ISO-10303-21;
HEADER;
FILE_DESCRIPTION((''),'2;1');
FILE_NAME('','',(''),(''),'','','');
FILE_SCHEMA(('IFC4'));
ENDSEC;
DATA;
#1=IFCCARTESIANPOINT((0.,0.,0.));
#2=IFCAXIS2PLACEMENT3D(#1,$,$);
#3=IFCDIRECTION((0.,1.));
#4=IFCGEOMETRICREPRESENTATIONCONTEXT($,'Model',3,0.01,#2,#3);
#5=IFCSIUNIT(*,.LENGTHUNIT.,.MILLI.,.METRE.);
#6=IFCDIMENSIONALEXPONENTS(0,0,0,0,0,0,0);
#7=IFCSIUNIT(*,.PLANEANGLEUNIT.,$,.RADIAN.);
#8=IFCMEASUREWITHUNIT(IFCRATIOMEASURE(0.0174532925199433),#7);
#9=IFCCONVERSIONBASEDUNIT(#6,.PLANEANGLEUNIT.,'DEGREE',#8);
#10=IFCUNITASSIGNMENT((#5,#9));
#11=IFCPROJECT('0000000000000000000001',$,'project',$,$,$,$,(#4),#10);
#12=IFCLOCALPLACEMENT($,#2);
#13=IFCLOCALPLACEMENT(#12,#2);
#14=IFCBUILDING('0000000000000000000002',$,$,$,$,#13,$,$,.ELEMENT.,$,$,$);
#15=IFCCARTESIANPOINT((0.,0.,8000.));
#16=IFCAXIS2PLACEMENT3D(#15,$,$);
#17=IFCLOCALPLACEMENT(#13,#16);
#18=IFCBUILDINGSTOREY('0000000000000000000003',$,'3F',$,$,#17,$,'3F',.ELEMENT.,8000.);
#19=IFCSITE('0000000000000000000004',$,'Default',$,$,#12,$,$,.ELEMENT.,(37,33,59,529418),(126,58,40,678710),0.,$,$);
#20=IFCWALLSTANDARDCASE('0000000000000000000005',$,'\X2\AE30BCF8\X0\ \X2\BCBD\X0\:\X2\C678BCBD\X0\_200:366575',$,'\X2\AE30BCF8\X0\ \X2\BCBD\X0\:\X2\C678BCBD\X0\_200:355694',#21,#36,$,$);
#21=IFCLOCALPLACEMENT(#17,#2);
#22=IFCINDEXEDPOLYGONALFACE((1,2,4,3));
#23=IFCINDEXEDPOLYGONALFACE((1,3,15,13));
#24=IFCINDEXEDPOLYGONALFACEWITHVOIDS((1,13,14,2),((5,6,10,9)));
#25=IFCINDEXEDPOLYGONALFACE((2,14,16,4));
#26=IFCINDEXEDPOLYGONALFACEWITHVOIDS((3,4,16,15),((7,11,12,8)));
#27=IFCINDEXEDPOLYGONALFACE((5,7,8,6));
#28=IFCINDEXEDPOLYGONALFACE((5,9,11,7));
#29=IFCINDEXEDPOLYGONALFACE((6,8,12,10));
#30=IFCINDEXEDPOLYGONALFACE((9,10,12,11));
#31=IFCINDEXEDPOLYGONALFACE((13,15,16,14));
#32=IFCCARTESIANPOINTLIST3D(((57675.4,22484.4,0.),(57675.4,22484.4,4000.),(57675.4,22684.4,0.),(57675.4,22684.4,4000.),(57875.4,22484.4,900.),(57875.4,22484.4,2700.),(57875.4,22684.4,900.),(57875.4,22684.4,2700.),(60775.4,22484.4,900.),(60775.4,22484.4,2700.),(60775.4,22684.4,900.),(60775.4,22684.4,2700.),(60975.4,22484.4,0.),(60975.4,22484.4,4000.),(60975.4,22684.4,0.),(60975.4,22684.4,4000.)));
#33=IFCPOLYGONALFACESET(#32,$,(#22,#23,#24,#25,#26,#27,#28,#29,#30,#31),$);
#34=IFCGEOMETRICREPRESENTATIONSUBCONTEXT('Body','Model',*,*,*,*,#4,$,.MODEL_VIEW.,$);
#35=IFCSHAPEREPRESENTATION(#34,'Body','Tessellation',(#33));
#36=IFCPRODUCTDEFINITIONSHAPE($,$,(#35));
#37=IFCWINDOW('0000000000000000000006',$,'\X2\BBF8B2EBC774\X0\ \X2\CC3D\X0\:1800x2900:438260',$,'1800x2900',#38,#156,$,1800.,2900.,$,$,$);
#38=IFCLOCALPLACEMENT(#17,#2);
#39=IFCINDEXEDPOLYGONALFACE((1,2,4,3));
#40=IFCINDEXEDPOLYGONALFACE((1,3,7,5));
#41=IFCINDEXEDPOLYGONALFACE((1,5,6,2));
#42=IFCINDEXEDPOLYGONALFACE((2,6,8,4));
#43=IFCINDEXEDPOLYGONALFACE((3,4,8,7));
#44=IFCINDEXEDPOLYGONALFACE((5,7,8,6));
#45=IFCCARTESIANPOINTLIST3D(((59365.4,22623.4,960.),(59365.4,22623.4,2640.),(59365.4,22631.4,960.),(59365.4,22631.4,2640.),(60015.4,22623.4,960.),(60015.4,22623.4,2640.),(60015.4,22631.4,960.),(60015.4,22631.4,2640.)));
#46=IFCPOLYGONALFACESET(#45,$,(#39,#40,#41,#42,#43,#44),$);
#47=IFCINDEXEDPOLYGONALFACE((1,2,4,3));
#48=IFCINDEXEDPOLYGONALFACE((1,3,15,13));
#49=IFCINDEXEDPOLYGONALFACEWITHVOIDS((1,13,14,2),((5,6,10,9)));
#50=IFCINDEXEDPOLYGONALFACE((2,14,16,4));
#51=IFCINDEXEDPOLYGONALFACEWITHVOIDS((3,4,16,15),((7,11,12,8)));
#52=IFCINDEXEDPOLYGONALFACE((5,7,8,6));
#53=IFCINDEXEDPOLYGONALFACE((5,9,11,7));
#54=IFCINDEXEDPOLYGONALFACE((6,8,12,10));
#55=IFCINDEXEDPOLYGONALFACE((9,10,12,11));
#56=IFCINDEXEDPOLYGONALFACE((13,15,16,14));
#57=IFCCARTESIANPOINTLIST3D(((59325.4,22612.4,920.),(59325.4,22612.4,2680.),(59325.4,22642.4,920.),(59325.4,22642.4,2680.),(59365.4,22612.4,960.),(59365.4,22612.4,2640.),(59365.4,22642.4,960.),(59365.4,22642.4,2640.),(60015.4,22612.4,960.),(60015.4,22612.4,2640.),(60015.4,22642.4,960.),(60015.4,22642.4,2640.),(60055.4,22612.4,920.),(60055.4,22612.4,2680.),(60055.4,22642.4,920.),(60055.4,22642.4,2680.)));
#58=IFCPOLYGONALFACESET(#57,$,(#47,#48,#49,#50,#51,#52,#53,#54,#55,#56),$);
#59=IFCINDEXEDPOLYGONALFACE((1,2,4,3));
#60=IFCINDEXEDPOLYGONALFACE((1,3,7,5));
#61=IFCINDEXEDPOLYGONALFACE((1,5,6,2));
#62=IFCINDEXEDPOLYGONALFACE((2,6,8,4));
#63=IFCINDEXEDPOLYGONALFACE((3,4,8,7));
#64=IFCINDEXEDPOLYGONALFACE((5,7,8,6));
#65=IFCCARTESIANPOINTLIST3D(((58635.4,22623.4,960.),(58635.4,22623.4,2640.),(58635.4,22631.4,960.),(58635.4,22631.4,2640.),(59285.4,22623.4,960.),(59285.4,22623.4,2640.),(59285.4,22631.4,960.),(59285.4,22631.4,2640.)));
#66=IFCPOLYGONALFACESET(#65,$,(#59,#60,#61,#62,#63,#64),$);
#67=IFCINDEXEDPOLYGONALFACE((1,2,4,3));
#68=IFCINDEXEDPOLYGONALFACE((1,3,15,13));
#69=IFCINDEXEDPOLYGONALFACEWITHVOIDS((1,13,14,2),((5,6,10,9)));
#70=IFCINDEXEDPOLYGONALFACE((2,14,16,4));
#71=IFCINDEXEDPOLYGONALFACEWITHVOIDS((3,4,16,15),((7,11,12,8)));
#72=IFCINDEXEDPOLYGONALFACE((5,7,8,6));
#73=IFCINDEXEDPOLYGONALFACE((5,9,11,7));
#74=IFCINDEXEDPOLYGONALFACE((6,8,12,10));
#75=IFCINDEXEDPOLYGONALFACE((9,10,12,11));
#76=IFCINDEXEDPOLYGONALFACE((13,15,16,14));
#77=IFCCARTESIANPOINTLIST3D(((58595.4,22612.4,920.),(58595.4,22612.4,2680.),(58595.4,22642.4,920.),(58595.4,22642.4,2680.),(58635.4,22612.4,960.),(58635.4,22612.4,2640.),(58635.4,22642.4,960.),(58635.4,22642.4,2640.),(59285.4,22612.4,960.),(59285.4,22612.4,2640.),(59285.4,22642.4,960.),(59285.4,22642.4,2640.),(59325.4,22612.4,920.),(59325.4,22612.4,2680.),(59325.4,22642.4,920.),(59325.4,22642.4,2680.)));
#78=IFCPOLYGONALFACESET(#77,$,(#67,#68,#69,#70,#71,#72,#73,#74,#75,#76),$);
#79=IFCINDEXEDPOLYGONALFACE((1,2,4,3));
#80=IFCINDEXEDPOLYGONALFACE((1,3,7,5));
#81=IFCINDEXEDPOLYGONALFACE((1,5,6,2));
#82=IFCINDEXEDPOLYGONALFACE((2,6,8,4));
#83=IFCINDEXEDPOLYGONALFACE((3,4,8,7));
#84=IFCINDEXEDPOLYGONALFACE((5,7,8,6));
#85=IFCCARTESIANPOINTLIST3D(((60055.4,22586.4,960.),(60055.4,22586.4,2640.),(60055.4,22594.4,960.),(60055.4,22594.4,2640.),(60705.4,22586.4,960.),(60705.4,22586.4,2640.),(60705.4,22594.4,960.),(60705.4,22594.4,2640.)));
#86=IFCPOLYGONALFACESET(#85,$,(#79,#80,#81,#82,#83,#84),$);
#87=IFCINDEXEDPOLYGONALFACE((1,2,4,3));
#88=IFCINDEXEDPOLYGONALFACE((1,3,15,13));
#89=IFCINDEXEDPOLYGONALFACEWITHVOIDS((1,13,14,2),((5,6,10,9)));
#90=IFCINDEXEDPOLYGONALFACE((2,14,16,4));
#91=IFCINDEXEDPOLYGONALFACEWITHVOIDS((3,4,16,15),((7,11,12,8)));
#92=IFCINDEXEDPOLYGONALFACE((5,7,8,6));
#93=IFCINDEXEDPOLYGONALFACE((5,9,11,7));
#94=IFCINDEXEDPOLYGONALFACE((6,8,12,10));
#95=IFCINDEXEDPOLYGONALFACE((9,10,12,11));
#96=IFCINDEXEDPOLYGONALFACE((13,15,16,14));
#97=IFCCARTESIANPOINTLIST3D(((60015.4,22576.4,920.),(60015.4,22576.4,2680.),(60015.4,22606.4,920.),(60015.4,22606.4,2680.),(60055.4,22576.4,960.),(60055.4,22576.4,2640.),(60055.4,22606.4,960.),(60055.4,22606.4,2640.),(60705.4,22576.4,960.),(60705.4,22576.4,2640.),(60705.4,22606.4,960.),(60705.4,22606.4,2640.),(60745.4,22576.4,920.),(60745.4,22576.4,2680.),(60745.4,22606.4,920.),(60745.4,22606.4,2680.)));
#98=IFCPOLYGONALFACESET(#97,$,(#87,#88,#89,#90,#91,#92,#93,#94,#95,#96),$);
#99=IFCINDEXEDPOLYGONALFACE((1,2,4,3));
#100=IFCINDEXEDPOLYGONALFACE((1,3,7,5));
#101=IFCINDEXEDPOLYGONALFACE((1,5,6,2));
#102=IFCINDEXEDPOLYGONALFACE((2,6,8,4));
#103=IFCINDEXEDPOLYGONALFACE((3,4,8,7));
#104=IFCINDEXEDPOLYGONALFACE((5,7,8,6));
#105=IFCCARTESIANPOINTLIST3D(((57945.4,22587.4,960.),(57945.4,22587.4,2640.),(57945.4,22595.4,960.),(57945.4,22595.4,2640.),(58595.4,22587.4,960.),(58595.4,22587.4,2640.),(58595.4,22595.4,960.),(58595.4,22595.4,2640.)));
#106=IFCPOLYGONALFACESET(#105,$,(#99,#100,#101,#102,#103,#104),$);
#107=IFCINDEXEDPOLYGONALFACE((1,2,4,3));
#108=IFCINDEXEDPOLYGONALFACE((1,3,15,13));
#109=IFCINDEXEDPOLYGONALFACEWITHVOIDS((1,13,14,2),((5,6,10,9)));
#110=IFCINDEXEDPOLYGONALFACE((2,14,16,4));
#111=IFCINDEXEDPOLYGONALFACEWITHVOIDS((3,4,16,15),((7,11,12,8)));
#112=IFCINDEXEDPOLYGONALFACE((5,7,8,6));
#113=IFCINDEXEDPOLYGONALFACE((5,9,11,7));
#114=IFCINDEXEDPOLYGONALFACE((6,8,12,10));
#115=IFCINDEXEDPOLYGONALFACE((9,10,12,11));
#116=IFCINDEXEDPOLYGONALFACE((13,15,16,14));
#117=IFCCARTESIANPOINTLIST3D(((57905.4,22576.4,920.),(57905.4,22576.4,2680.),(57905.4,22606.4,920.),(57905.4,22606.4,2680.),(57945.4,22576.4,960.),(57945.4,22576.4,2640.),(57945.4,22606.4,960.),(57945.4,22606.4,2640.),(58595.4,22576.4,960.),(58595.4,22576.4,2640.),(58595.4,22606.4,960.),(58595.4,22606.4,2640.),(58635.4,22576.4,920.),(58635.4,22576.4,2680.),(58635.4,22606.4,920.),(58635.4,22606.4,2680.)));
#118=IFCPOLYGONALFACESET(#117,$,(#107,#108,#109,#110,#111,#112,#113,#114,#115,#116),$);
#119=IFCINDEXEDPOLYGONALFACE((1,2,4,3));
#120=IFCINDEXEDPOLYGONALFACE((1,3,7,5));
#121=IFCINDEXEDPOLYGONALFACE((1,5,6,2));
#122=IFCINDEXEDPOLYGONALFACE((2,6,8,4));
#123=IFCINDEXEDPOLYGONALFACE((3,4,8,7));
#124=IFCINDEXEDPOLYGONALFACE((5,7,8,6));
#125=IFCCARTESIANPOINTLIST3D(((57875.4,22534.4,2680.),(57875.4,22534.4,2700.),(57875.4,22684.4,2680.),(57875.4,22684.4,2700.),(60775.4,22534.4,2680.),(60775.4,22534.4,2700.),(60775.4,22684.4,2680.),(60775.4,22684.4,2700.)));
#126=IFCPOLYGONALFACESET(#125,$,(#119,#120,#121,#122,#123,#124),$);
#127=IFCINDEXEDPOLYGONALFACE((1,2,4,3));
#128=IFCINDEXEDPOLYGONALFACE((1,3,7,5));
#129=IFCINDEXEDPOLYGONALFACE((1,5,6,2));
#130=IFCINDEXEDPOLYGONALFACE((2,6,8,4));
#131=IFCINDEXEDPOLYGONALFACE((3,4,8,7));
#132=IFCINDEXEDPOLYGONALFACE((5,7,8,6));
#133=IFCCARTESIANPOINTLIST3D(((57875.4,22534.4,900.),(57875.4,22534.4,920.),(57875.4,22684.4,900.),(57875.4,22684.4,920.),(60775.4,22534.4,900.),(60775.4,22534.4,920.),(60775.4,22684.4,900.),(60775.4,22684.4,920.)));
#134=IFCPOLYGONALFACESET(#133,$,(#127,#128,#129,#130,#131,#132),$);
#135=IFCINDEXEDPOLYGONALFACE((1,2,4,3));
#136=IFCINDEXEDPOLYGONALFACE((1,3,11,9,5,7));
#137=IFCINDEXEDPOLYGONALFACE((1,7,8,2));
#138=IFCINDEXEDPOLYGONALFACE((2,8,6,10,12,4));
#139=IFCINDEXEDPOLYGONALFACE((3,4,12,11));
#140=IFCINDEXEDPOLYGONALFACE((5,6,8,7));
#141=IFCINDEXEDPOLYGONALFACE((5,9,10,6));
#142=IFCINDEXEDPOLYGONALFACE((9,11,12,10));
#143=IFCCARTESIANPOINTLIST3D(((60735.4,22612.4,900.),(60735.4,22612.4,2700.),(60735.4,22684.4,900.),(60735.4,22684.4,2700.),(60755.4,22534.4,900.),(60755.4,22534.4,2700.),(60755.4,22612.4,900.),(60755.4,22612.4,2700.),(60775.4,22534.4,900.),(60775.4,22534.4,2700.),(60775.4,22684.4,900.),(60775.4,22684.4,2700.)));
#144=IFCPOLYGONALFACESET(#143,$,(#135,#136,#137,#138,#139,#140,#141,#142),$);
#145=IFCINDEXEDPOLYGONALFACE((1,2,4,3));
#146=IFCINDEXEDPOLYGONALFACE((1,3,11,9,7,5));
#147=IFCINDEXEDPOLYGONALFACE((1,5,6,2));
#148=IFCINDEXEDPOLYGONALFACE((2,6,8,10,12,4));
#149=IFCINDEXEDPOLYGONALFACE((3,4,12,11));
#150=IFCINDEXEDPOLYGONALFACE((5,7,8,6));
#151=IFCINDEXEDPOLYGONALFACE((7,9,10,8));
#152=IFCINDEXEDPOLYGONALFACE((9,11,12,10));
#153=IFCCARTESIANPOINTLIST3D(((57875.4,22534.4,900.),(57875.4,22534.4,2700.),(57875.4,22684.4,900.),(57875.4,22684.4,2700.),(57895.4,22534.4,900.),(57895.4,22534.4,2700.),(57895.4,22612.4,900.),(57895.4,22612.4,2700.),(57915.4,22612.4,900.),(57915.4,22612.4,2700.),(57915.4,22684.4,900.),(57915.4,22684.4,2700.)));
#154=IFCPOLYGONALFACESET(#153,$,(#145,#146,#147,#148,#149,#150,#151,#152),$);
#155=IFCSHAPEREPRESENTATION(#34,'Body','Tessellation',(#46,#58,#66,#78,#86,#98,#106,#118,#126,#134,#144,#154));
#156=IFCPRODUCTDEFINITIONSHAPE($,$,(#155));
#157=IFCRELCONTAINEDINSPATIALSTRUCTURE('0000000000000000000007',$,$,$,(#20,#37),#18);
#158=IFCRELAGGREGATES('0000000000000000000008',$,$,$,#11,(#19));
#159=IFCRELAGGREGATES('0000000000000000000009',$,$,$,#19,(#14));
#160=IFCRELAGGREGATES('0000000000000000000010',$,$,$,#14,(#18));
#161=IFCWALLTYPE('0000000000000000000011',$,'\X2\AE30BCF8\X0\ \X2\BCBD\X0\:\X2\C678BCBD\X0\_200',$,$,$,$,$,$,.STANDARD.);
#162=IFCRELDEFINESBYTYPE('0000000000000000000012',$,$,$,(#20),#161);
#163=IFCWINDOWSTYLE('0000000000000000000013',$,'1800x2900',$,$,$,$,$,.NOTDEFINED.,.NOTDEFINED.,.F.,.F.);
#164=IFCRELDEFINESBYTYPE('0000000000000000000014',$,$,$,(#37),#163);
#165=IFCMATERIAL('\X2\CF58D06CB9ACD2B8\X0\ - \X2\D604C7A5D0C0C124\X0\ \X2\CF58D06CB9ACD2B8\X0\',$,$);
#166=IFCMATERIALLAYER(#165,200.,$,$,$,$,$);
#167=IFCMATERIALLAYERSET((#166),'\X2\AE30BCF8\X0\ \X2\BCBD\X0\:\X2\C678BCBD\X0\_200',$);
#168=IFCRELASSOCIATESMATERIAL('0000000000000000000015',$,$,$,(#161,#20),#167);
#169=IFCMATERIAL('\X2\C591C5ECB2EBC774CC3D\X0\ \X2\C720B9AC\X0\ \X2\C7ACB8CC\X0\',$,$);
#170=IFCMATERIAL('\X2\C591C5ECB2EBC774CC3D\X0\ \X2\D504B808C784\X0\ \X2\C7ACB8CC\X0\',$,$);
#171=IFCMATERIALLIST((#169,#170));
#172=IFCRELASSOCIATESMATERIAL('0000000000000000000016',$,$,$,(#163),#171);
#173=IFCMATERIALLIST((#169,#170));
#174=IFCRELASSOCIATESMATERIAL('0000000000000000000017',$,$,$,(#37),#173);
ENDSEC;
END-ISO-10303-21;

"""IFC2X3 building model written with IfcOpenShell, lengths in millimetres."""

from ifc_helpers import new_model, entity, si_unit, converted_unit, direction, frame, frame_2d, origin, origin_2d_with_axis, place, context, subcontext, project, spatial, polyline, rectangle, outline, extrude, source, transform, mapped, material, material_list, layer, layer_set, layer_usage, type_object, type_shapes, element, fill, save


model = new_model("IFC2X3")

# Units and contexts
model_context = context("Model", 3, precision=0.01, world=origin(), true_north=direction((0.0, 1.0)))
body_context = subcontext(model_context, "Body", "Model", "MODEL_VIEW")
ifc_project = project(units=[si_unit("LENGTHUNIT", "METRE", prefix="MILLI"), converted_unit("PLANEANGLEUNIT", "DEGREE", entity("IfcRatioMeasure", 0.0174532925199433), si_unit("PLANEANGLEUNIT", "RADIAN"), dimensions=[0, 0, 0, 0, 0, 0, 0])], contexts=[model_context])

# Site, building, storey
site_placement = place(None, origin())
site = spatial("IfcSite", under=ifc_project, at=site_placement, Name="Default", CompositionType="ELEMENT", RefLatitude=(37, 33, 59, 529418), RefLongitude=(126, 58, 40, 678710), RefElevation=0.0)
building_placement = place(site_placement, origin())
building = spatial("IfcBuilding", under=site, at=building_placement, CompositionType="ELEMENT")
storey_placement = place(building_placement, frame((0.0, 0.0, 8000.0)))
storey = spatial("IfcBuildingStorey", under=building, at=storey_placement, Name="3F", LongName="3F", CompositionType="ELEMENT", Elevation=8000.0)

# Wall, opening, window
ifc_material_1 = material(Name="콘크리트 - 현장타설 콘크리트")
ifc_layer_1 = layer(ifc_material_1, 200.0)
ifc_layer_set_1 = layer_set([ifc_layer_1], Name="기본 벽:외벽_200")
wall_type_1 = type_object("IfcWallType", Name="기본 벽:외벽_200", PredefinedType="STANDARD", material=ifc_layer_set_1)
ifc_material_2 = material(Name="양여닫이창 유리 재료")
ifc_material_3 = material(Name="양여닫이창 프레임 재료")
ifc_material_list_1 = material_list([ifc_material_2, ifc_material_3])
window_style = type_object("IfcWindowStyle", Name="1800x2900", ConstructionType="NOTDEFINED", OperationType="NOTDEFINED", ParameterTakesPrecedence=False, Sizeable=False, material=ifc_material_list_1)
shared_shape_1 = source(origin(), body_context, "Body", "SweptSolid", [
    extrude(rectangle(XDim=8.0, YDim=650.0, at=frame_2d((0.0, 0.0), x_axis=(1.0, 0.0))), frame((1815.0, 143.0, 60.0), z_axis=(0.0, 0.0, 1.0), x_axis=(0.0, 1.0, 0.0)), (0.0, 0.0, 1.0), 1680.0),
    extrude(outline(polyline([(-880.0, -365.0), (880.0, -365.0), (880.0, 365.0), (-880.0, 365.0), (-880.0, -365.0)]), holes=[polyline([(840.0, -325.0), (-840.0, -325.0), (-840.0, 325.0), (840.0, 325.0), (840.0, -325.0)])]), frame((1815.0, 128.0, 900.0), z_axis=(0.0, 1.0, 0.0), x_axis=(0.0, 0.0, -1.0)), (0.0, 0.0, 1.0), 30.0),
    extrude(rectangle(XDim=8.0, YDim=650.0, at=frame_2d((0.0, 0.0), x_axis=(1.0, 0.0))), frame((1085.0, 143.0, 60.0), z_axis=(0.0, 0.0, 1.0), x_axis=(0.0, 1.0, 0.0)), (0.0, 0.0, 1.0), 1680.0),
    extrude(outline(polyline([(-880.0, -365.0), (880.0, -365.0), (880.0, 365.0), (-880.0, 365.0), (-880.0, -365.0)]), holes=[polyline([(840.0, -325.0), (-840.0, -325.0), (-840.0, 325.0), (840.0, 325.0), (840.0, -325.0)])]), frame((1085.0, 128.0, 900.0), z_axis=(0.0, 1.0, 0.0), x_axis=(0.0, 0.0, -1.0)), (0.0, 0.0, 1.0), 30.0),
    extrude(rectangle(XDim=8.0, YDim=650.0, at=frame_2d((0.0, 0.0), x_axis=(1.0, 0.0))), frame((2505.0, 106.0, 60.0), z_axis=(0.0, 0.0, 1.0), x_axis=(0.0, 1.0, 0.0)), (0.0, 0.0, 1.0), 1680.0),
    extrude(outline(polyline([(-880.0, -365.0), (880.0, -365.0), (880.0, 365.0), (-880.0, 365.0), (-880.0, -365.0)]), holes=[polyline([(840.0, -325.0), (-840.0, -325.0), (-840.0, 325.0), (840.0, 325.0), (840.0, -325.0)])]), frame((2505.0, 92.0, 900.0), z_axis=(0.0, 1.0, 0.0), x_axis=(0.0, 0.0, -1.0)), (0.0, 0.0, 1.0), 30.0),
    extrude(rectangle(XDim=8.0, YDim=650.0, at=origin_2d_with_axis()), frame((395.0, 107.0, 60.0), z_axis=(0.0, 0.0, 1.0), x_axis=(0.0, 1.0, 0.0)), (0.0, 0.0, 1.0), 1680.0),
    extrude(outline(polyline([(-880.0, -365.0), (880.0, -365.0), (880.0, 365.0), (-880.0, 365.0), (-880.0, -365.0)]), holes=[polyline([(840.0, -325.0), (-840.0, -325.0), (-840.0, 325.0), (840.0, 325.0), (840.0, -325.0)])]), frame((395.0, 92.0, 900.0), z_axis=(0.0, 1.0, 0.0), x_axis=(0.0, 0.0, -1.0)), (0.0, 0.0, 1.0), 30.0),
    extrude(rectangle(XDim=2900.0, YDim=150.0, at=origin_2d_with_axis()), frame((1450.0, 125.0, 1780.0), z_axis=(0.0, 0.0, 1.0), x_axis=(-1.0, 0.0, 0.0)), (0.0, 0.0, 1.0), 20.0),
    extrude(rectangle(XDim=2900.0, YDim=150.0, at=origin_2d_with_axis()), frame((1450.0, 125.0, 0.0), z_axis=(0.0, 0.0, 1.0), x_axis=(-1.0, 0.0, 0.0)), (0.0, 0.0, 1.0), 20.0),
    extrude(outline(polyline([(-74.0, -20.0), (-2.0, -20.0), (-2.0, 0.0), (76.0, 0.0), (76.0, 20.0), (-74.0, 20.0), (-74.0, -20.0)])), frame((2880.0, 126.0, 0.0), z_axis=(0.0, 0.0, 1.0), x_axis=(0.0, -1.0, 0.0)), (0.0, 0.0, 1.0), 1800.0),
    extrude(outline(polyline([(-20.0, -74.0), (20.0, -74.0), (20.0, 76.0), (0.0, 76.0), (0.0, -2.0), (-20.0, -2.0), (-20.0, -74.0)])), frame((20.0, 126.0, 0.0), z_axis=(0.0, 0.0, 1.0), x_axis=(-1.0, 0.0, 0.0)), (0.0, 0.0, 1.0), 1800.0),
])
type_shapes(window_style, [shared_shape_1])
ifc_layer_usage_1 = layer_usage(ifc_layer_set_1, "AXIS2", "NEGATIVE", 100.0)
wall_1_placement = place(storey_placement, frame((60975.4, 22584.4, 0.0), z_axis=(0.0, 0.0, 1.0), x_axis=(-1.0, 0.0, 0.0)))
wall_1 = element("IfcWallStandardCase", 1, at=wall_1_placement, inside=storey, type_object=wall_type_1, material=ifc_layer_usage_1, Name="기본 벽:외벽_200:366575", ObjectType="기본 벽:외벽_200:355694", context=body_context, shape_type="SweptSolid", body=[
    extrude(rectangle(XDim=3300.0, YDim=200.0, at=frame_2d((1650.0, 0.0), x_axis=(-1.0, 0.0))), origin(), (0.0, 0.0, 1.0), 4000.0),
])
opening_1_placement = place(wall_1_placement, frame((3100.0, 100.0, 900.0)))
opening_1 = element("IfcOpeningElement", 2, at=opening_1_placement, cuts=wall_1, ObjectType="Opening", context=body_context, shape_type="SweptSolid", body=[
    extrude(rectangle(XDim=1800.0, YDim=2900.0, at=frame_2d((900.0, 1450.0), x_axis=(1.0, 0.0))), frame((0.0, 0.0, 0.0), z_axis=(0.0, -1.0, 0.0), x_axis=(0.0, 0.0, 1.0)), (0.0, 0.0, 1.0), 200.0),
])
ifc_material_list_2 = material_list([ifc_material_2, ifc_material_3])
window_1_placement = place(opening_1_placement, frame((0.0, 0.0, 0.0), z_axis=(0.0, 0.0, 1.0), x_axis=(-1.0, 0.0, 0.0)))
window_1 = element("IfcWindow", 3, at=window_1_placement, inside=storey, type_object=window_style, material=ifc_material_list_2, Name="미닫이 창:1800x2900:438260", ObjectType="1800x2900", OverallHeight=1800.0, OverallWidth=2900.0, context=body_context, shape_type="MappedRepresentation", body=[
    mapped(shared_shape_1, transform((0.0, 0.0, 0.0), scale=1.0)),
])
fill(opening_1, window_1)

save(model, "model.ifc")
